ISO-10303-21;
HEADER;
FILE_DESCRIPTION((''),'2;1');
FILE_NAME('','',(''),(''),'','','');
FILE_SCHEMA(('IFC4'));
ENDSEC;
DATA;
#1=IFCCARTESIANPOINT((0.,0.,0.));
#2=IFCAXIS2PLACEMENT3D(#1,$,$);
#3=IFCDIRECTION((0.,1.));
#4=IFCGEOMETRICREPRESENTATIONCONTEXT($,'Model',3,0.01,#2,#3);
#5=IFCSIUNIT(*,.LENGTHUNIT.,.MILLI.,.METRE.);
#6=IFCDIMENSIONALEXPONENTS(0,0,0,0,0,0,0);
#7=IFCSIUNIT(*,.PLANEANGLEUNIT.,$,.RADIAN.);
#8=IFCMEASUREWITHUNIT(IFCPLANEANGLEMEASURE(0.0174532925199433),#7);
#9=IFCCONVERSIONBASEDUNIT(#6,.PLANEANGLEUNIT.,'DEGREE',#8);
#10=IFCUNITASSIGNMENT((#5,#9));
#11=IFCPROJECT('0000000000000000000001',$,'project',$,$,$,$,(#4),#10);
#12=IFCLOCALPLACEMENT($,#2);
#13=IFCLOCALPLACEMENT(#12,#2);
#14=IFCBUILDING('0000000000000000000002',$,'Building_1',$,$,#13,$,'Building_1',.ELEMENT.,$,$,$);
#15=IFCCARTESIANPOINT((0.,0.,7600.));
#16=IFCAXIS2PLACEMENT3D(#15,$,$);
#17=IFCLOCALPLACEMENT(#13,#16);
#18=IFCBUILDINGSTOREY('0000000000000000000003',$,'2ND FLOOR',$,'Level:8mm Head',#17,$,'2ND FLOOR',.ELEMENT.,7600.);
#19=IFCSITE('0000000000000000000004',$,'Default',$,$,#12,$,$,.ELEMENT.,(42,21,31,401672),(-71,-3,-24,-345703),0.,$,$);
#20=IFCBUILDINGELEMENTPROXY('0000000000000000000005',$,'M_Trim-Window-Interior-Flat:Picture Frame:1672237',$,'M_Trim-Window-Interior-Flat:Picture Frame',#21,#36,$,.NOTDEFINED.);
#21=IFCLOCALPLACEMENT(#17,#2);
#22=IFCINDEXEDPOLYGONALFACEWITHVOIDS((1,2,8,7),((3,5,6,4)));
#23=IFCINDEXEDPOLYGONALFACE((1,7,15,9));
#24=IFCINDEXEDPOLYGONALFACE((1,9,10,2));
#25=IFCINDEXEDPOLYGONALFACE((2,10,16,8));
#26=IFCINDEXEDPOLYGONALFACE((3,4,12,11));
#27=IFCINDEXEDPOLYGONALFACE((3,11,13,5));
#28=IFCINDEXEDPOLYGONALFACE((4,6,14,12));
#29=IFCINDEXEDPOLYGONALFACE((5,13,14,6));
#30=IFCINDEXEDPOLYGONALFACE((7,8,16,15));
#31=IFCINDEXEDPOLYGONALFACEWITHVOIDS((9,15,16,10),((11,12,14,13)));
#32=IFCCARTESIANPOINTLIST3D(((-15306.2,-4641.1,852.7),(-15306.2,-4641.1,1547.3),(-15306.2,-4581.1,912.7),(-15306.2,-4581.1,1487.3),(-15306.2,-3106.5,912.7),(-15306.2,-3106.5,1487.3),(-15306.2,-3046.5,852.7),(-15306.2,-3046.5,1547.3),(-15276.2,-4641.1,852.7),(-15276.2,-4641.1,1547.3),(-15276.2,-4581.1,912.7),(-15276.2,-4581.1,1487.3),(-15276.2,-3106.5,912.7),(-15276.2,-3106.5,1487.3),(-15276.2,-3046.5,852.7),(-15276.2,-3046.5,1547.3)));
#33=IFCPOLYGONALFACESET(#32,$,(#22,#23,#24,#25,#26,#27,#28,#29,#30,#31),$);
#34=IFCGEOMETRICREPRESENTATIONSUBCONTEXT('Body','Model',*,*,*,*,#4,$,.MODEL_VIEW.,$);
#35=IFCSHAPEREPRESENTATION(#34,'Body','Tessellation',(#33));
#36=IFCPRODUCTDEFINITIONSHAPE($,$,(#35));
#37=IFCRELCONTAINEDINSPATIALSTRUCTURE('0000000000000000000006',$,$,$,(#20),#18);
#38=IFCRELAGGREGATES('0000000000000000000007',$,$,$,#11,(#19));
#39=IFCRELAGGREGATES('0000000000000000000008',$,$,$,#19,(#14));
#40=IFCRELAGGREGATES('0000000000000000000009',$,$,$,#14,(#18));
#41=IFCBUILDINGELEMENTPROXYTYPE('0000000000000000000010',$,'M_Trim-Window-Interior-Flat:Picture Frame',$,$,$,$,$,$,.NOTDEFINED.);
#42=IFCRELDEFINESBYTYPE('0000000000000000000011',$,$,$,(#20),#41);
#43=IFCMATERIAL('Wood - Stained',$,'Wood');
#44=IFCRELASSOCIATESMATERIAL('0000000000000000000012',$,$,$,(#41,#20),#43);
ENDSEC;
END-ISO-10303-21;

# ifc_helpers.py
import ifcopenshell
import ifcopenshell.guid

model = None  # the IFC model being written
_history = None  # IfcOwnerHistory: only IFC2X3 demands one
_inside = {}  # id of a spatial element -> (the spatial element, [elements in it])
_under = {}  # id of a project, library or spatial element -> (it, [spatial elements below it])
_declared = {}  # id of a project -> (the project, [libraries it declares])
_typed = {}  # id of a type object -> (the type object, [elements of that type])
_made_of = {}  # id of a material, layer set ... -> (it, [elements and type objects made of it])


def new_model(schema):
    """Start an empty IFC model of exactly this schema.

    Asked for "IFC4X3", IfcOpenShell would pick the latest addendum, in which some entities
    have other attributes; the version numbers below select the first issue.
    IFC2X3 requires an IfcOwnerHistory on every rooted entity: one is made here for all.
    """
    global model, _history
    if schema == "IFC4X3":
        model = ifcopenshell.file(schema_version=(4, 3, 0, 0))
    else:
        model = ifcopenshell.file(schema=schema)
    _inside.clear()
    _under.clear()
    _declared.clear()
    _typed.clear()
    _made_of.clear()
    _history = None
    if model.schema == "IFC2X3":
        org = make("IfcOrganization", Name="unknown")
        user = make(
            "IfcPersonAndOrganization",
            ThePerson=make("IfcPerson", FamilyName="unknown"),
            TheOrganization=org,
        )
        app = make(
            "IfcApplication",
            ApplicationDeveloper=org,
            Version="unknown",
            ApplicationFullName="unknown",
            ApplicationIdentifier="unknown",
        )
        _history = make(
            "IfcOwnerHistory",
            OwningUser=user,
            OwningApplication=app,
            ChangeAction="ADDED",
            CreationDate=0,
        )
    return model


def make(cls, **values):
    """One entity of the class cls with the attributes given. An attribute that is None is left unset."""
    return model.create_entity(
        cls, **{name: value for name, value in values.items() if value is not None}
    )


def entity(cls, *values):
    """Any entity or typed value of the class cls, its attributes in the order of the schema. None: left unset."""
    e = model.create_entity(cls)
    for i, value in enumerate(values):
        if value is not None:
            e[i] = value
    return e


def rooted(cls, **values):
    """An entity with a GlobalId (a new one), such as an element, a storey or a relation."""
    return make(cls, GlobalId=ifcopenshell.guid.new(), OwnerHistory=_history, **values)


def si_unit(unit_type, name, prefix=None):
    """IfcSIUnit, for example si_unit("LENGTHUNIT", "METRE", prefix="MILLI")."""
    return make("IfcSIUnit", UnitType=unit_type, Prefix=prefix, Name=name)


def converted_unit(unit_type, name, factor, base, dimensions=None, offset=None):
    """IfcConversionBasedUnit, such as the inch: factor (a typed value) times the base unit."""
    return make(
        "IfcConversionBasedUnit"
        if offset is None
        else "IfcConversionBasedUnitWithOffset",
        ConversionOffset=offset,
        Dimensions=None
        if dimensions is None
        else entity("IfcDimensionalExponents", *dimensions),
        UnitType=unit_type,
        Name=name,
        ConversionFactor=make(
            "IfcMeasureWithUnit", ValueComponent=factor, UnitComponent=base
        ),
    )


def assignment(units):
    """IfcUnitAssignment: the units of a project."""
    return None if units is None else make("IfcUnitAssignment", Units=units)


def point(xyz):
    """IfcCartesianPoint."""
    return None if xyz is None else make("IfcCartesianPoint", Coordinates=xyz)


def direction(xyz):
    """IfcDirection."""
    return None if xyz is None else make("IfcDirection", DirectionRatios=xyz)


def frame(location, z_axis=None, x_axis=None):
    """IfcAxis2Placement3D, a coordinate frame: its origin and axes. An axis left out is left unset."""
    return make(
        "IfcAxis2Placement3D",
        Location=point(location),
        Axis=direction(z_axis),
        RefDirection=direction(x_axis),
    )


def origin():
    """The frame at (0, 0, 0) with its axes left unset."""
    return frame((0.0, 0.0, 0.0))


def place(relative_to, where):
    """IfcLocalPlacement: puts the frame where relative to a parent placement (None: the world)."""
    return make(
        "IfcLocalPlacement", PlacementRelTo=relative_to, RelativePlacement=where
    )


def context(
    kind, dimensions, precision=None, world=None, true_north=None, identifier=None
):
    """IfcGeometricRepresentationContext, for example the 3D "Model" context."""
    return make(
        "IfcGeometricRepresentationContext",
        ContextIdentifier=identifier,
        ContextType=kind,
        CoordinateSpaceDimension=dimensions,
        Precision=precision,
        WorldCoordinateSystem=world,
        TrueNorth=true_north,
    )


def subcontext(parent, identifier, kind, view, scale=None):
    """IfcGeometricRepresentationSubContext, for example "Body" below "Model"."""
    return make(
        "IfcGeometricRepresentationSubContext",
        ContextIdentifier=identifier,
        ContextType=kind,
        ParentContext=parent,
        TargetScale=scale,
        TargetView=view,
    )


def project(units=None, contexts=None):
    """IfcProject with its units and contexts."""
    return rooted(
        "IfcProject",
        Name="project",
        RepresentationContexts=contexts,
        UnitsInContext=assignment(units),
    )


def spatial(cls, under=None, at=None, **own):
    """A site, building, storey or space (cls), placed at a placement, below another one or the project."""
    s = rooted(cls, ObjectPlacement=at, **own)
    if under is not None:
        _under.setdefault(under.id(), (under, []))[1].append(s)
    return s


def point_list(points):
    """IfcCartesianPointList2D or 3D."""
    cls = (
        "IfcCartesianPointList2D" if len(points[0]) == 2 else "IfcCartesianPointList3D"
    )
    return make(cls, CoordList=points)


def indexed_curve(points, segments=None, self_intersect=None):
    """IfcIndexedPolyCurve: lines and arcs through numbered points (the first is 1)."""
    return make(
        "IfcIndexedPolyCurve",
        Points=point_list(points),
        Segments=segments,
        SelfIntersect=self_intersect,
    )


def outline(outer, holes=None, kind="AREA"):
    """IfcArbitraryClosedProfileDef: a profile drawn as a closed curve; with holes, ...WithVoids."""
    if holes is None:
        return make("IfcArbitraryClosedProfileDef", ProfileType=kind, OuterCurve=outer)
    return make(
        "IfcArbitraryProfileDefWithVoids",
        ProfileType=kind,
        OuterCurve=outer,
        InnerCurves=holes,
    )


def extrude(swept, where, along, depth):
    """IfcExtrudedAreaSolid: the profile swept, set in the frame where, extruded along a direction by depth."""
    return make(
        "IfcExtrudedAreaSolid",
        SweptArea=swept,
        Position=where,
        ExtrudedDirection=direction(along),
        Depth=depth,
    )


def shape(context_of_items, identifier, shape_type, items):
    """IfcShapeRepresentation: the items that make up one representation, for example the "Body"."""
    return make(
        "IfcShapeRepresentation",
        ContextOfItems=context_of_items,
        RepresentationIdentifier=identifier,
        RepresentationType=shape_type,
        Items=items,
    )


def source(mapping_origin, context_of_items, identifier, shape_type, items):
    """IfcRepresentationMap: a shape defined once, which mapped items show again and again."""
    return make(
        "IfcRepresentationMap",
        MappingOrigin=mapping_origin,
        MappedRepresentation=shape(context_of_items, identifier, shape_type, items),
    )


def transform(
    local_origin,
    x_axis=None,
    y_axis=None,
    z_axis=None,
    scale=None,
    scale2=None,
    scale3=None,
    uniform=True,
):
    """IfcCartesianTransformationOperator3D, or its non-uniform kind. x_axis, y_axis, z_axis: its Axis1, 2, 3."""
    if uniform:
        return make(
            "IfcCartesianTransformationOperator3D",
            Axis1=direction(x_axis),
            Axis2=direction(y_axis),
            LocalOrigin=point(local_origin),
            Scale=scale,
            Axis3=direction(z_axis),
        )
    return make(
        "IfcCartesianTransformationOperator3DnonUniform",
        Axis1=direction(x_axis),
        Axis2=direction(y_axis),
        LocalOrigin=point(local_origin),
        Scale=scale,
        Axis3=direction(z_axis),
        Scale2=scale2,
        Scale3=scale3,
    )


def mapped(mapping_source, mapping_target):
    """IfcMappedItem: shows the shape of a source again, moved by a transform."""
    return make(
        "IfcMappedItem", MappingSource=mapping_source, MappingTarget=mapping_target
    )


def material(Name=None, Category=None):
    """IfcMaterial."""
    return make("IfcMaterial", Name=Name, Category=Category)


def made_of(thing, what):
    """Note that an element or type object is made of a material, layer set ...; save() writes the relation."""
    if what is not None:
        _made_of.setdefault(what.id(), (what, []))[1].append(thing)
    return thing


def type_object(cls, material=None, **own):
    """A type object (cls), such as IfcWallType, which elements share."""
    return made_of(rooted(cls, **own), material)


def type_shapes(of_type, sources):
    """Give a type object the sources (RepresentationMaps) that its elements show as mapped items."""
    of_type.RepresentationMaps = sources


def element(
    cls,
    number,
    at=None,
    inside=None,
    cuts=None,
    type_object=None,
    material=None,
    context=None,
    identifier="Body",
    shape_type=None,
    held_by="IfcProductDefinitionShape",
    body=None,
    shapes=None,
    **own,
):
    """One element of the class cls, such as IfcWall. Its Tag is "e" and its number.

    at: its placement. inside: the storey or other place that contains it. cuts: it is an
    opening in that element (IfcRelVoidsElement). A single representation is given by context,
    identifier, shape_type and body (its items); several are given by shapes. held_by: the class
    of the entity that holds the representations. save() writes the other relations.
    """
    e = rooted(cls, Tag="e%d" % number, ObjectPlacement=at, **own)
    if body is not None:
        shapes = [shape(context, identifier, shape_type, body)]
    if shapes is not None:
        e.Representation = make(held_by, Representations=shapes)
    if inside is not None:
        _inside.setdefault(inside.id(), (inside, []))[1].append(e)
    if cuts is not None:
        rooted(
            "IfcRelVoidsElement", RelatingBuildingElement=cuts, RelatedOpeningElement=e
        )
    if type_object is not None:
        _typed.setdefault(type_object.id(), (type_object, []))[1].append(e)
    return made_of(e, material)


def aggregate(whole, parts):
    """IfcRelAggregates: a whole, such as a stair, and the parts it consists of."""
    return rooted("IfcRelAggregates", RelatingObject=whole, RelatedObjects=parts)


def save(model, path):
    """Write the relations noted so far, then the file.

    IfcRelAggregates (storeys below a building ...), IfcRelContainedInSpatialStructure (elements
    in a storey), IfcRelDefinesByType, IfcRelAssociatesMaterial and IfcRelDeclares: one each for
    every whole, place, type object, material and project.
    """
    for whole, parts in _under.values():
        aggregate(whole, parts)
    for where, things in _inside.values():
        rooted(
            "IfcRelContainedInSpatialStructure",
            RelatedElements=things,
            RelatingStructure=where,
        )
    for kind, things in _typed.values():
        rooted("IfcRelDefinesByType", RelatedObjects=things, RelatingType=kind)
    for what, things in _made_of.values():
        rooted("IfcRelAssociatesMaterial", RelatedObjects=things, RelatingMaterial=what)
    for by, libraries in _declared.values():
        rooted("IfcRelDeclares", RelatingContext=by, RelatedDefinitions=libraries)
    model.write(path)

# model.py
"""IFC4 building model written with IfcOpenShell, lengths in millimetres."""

from ifc_helpers import new_model, entity, si_unit, converted_unit, direction, frame, origin, place, context, subcontext, project, spatial, indexed_curve, outline, extrude, source, transform, mapped, material, type_object, type_shapes, element, save


model = new_model("IFC4")

# Units and contexts
model_context = context("Model", 3, precision=0.01, world=origin(), true_north=direction((0.0, 1.0)))
body_context = subcontext(model_context, "Body", "Model", "MODEL_VIEW")
ifc_project = project(units=[si_unit("LENGTHUNIT", "METRE", prefix="MILLI"), converted_unit("PLANEANGLEUNIT", "DEGREE", entity("IfcPlaneAngleMeasure", 0.0174532925199433), si_unit("PLANEANGLEUNIT", "RADIAN"), dimensions=[0, 0, 0, 0, 0, 0, 0])], contexts=[model_context])

# Site, building, storey
site_placement = place(None, origin())
site = spatial("IfcSite", under=ifc_project, at=site_placement, Name="Default", CompositionType="ELEMENT", RefLatitude=(42, 21, 31, 401672), RefLongitude=(-71, -3, -24, -345703), RefElevation=0.0)
building_placement = place(site_placement, origin())
building = spatial("IfcBuilding", under=site, at=building_placement, Name="Building_1", LongName="Building_1", CompositionType="ELEMENT")
storey_placement = place(building_placement, frame((0.0, 0.0, 7600.0)))
storey = spatial("IfcBuildingStorey", under=building, at=storey_placement, Name="2ND FLOOR", ObjectType="Level:8mm Head", LongName="2ND FLOOR", CompositionType="ELEMENT", Elevation=7600.0)

# Shared definitions
ifc_material_1 = material(Name="Wood - Stained", Category="Wood")

# Building element proxy
building_element_proxy_type_1 = type_object("IfcBuildingElementProxyType", Name="M_Trim-Window-Interior-Flat:Picture Frame", PredefinedType="NOTDEFINED", material=ifc_material_1)
shared_shape_1 = source(origin(), body_context, "Body", "SweptSolid", [
    extrude(outline(indexed_curve([(-797.3, -347.3), (797.3, -347.3), (797.3, 347.3), (-797.3, 347.3), (-797.3, -347.3)], self_intersect=False), holes=[indexed_curve([(-737.3, -287.3), (-737.3, 287.3), (737.3, 287.3), (737.3, -287.3), (-737.3, -287.3)], self_intersect=False)]), frame((0.0, -300.0, 0.0), z_axis=(0.0, 0.0, 1.0), x_axis=(-1.0, 0.0, 0.0)), (0.0, 0.0, 1.0), 30.0),
])
type_shapes(building_element_proxy_type_1, [shared_shape_1])
for number, where, z_axis, x_axis, name in (
    (1, (-15276.2, -3843.8, 1500.0), (-1.0, 0.0, 0.0), (0.0, -1.0, 0.0), "M_Trim-Window-Interior-Flat:Picture Frame:1672237"),
):
    element("IfcBuildingElementProxy", number, at=place(storey_placement, frame(where, z_axis=z_axis, x_axis=x_axis)), inside=storey, type_object=building_element_proxy_type_1, material=ifc_material_1, Name=name, ObjectType="M_Trim-Window-Interior-Flat:Picture Frame", PredefinedType="NOTDEFINED", context=body_context, shape_type="MappedRepresentation", body=[
        mapped(shared_shape_1, transform((0.0, 0.0, 0.0), scale=1.0)),
    ])

save(model, "model.ifc")
